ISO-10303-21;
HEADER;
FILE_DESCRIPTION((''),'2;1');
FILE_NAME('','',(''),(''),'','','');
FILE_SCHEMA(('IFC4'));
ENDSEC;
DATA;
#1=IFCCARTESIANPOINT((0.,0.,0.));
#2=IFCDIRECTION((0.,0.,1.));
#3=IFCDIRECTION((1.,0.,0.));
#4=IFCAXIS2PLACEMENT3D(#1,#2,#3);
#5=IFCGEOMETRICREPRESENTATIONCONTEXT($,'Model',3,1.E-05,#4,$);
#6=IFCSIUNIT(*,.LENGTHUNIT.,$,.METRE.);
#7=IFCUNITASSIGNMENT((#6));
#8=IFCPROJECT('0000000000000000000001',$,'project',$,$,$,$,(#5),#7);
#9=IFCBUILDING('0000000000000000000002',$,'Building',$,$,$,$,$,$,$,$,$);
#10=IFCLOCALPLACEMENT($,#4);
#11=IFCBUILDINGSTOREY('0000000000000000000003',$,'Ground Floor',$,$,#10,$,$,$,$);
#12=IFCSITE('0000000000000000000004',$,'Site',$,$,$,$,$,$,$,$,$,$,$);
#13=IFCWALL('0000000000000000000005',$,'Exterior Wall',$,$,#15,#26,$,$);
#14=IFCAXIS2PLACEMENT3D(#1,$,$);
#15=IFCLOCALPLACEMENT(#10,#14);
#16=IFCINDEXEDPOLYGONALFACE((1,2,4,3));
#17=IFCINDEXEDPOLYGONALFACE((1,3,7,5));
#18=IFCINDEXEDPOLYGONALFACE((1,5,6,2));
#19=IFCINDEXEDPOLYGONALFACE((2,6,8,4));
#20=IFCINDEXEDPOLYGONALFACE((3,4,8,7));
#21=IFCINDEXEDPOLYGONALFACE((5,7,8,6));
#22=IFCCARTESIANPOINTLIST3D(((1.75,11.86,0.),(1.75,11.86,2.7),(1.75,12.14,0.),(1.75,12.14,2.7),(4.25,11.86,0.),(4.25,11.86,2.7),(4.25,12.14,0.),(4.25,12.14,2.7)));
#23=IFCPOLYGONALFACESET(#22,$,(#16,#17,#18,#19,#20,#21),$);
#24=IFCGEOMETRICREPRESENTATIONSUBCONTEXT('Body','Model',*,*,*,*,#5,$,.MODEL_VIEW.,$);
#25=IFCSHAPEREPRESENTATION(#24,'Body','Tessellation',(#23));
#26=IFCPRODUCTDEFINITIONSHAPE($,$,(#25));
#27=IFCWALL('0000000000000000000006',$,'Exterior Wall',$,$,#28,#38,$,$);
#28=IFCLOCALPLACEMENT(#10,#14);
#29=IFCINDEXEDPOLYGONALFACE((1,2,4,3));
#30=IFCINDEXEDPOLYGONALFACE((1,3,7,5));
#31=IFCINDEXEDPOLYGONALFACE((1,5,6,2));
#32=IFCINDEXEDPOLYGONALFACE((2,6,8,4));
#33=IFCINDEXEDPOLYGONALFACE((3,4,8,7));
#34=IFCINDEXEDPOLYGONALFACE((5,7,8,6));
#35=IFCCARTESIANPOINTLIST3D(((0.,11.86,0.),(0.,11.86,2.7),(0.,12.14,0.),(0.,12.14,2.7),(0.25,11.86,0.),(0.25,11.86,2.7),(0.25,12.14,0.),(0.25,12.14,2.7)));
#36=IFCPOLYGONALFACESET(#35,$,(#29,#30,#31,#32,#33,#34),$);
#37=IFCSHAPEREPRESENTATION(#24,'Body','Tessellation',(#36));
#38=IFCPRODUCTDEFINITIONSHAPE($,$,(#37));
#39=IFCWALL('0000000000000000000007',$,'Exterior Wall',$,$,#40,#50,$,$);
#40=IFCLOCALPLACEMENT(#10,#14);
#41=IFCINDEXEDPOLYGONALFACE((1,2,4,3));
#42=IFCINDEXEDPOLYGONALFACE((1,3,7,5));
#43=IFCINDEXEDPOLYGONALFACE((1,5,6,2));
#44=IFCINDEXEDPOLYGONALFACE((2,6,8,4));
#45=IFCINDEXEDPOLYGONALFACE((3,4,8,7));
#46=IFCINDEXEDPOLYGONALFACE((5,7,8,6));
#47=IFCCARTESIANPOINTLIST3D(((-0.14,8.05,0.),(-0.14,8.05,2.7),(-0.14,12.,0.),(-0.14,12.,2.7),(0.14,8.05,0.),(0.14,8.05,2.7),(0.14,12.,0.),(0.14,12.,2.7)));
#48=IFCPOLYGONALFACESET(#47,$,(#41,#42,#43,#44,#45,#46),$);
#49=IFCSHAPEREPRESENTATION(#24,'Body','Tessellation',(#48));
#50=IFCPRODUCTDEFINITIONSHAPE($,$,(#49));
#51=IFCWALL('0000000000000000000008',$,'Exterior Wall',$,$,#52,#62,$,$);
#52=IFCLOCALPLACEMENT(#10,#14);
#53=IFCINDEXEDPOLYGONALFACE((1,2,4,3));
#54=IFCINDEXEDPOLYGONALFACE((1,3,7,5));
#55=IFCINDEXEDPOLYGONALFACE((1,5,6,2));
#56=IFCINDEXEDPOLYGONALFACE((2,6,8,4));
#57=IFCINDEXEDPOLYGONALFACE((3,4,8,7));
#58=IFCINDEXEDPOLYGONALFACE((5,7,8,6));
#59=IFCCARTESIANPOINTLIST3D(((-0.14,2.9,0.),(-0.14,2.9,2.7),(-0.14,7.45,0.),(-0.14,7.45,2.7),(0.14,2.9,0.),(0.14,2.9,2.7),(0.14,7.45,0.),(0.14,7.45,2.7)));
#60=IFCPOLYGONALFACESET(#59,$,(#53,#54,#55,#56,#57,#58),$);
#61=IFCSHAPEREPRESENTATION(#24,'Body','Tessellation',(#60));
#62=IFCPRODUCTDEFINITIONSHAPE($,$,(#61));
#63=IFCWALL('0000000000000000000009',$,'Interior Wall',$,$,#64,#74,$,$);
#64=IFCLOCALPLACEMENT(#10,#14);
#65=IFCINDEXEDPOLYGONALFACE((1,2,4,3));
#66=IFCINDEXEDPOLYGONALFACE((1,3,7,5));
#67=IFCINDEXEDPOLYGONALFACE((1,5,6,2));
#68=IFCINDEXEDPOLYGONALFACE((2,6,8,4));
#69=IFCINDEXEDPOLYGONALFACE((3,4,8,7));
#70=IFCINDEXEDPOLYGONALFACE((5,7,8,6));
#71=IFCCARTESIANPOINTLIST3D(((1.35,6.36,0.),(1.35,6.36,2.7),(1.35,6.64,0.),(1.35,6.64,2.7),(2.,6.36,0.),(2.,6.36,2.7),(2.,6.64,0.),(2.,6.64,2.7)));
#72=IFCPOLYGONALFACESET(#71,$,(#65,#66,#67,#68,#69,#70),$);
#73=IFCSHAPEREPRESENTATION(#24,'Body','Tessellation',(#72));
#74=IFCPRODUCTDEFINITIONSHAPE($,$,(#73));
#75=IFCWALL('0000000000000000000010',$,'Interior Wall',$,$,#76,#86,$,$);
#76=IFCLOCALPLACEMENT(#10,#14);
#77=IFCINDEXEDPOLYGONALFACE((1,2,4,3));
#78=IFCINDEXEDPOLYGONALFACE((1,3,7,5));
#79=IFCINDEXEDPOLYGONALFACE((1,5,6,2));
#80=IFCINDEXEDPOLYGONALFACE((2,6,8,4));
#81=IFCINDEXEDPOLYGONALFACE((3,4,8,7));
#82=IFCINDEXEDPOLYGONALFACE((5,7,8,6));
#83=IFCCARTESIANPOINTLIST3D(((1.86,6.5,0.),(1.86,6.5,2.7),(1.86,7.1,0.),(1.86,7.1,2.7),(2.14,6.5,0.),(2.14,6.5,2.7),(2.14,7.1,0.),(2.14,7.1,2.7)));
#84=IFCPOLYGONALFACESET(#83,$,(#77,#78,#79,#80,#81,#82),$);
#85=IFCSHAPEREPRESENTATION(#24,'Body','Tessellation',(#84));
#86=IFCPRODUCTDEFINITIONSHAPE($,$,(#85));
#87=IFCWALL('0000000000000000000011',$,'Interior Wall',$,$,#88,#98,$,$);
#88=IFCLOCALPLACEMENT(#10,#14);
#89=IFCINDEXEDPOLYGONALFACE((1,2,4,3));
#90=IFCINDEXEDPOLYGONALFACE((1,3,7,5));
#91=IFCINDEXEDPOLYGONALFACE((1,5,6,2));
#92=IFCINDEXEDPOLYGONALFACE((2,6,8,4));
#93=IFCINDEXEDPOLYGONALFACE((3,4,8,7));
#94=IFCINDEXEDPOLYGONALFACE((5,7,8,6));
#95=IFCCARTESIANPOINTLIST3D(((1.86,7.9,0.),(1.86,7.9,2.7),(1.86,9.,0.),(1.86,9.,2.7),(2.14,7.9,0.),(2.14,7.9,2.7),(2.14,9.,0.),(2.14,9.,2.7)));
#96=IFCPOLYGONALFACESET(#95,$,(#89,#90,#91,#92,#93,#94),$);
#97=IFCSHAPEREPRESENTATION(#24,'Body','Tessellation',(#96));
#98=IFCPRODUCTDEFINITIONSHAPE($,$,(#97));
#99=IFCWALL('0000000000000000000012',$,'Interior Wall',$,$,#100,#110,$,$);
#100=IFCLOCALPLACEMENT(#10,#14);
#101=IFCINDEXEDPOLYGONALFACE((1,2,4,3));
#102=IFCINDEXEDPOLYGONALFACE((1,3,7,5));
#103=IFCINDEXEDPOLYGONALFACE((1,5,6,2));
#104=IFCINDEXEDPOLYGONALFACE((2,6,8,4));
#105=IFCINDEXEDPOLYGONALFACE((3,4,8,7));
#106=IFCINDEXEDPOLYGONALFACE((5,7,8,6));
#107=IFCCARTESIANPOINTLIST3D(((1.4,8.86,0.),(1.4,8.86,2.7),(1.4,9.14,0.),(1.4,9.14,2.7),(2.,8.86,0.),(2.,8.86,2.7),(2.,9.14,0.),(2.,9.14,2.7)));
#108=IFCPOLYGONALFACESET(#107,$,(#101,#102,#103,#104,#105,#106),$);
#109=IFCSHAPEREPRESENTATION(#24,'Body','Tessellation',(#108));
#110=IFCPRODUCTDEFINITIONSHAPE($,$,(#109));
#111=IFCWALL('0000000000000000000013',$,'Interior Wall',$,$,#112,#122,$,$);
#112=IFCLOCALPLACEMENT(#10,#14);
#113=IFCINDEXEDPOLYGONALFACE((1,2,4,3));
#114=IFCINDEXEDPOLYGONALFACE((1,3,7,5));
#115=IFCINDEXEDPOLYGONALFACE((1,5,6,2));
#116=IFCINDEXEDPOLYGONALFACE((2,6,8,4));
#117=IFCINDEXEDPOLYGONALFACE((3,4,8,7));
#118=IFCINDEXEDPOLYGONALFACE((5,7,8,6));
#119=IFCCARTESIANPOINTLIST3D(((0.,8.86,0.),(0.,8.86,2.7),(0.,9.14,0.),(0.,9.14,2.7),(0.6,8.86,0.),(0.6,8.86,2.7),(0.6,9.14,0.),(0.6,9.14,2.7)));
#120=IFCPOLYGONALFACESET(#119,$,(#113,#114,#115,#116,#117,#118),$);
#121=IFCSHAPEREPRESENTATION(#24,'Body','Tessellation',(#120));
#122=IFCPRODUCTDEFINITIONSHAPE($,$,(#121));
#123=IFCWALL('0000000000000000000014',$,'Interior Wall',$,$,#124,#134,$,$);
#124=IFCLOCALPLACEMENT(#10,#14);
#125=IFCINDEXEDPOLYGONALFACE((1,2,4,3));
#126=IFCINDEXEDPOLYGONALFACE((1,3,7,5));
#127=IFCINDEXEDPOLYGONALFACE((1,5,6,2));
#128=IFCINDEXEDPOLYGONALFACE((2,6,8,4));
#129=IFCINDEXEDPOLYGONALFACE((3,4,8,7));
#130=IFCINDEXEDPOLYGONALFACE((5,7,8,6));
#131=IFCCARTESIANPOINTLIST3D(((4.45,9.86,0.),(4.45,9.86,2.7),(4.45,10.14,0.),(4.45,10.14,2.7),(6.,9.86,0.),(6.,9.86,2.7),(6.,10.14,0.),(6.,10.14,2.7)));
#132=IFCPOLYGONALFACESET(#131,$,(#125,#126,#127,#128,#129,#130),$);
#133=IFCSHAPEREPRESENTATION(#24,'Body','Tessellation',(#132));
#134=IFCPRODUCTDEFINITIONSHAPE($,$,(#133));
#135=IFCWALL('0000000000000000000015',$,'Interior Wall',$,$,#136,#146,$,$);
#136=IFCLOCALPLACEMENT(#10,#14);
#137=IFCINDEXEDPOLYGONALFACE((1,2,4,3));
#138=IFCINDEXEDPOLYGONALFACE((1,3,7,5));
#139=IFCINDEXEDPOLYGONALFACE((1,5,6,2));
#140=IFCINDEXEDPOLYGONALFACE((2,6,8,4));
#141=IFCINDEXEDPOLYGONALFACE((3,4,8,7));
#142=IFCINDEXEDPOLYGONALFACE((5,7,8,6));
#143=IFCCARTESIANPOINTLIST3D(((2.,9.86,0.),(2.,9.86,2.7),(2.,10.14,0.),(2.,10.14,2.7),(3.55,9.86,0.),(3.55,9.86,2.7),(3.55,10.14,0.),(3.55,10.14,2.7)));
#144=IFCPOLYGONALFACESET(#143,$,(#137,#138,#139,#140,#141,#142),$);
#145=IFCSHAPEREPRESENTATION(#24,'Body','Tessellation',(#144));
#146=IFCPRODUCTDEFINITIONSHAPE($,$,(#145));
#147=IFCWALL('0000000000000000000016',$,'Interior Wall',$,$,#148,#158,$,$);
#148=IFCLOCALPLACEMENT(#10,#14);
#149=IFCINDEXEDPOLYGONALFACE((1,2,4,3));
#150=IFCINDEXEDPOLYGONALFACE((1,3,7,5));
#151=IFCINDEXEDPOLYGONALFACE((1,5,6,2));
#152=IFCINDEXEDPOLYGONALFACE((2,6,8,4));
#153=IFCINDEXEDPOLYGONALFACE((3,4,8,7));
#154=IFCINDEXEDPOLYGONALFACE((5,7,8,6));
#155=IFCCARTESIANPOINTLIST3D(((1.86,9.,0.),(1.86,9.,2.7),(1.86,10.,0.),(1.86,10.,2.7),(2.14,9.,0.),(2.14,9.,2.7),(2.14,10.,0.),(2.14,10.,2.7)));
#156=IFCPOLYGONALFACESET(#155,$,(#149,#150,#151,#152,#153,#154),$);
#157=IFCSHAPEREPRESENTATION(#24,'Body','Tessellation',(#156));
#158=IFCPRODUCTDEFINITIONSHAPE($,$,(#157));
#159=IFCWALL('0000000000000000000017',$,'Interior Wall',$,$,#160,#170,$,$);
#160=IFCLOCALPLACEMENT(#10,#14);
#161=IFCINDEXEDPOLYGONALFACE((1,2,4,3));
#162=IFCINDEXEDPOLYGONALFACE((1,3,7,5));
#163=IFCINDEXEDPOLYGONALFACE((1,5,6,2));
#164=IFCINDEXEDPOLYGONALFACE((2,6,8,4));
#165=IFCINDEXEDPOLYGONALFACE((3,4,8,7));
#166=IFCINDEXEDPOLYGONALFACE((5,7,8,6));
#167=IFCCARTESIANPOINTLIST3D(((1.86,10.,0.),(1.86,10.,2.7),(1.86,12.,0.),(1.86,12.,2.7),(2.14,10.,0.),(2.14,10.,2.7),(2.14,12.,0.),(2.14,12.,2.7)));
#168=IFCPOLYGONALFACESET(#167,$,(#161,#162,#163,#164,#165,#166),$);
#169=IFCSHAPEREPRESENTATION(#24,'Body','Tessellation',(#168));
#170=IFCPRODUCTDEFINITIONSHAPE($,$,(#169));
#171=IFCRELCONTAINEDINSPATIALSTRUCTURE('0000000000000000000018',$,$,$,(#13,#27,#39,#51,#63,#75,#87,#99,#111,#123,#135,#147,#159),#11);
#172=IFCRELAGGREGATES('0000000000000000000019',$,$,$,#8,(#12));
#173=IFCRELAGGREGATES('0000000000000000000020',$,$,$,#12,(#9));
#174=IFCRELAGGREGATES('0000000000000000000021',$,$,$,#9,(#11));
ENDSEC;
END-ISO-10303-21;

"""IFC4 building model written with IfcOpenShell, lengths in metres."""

from ifc_helpers import new_model, si_unit, frame, origin_with_axes, place, context, subcontext, project, spatial, indexed_curve, outline, extrude, element, save


model = new_model("IFC4")

# Units and contexts
model_context = context("Model", 3, precision=1e-05, world=origin_with_axes())
body_context = subcontext(model_context, "Body", "Model", "MODEL_VIEW")
ifc_project = project(units=[si_unit("LENGTHUNIT", "METRE")], contexts=[model_context])

# Site, building, storey
site = spatial("IfcSite", under=ifc_project, Name="Site")
building = spatial("IfcBuilding", under=site, Name="Building")
storey_placement = place(None, origin_with_axes())
storey = spatial("IfcBuildingStorey", under=building, at=storey_placement, Name="Ground Floor")

# Walls
wall_1_placement = place(storey_placement, frame((4.25, 12.0, 0.0), z_axis=(0.0, 0.0, 1.0), x_axis=(-1.0, 0.0, 0.0)))
element("IfcWall", 1, at=wall_1_placement, inside=storey, Name="Exterior Wall", context=body_context, shape_type="SweptSolid", body=[
    extrude(outline(indexed_curve([(0.0, 0.0), (0.0, 0.28), (2.5, 0.28), (2.5, 0.0), (0.0, 0.0)], self_intersect=False)), frame((0.0, -0.14, 0.0), z_axis=(0.0, 0.0, 1.0), x_axis=(1.0, 0.0, 0.0)), (0.0, 0.0, 1.0), 2.7),
])
wall_2_placement = place(storey_placement, frame((0.25, 12.0, 0.0), z_axis=(0.0, 0.0, 1.0), x_axis=(-1.0, 0.0, 0.0)))
element("IfcWall", 2, at=wall_2_placement, inside=storey, Name="Exterior Wall", context=body_context, shape_type="SweptSolid", body=[
    extrude(outline(indexed_curve([(0.0, 0.0), (0.0, 0.28), (0.25, 0.28), (0.25, 0.0), (0.0, 0.0)], self_intersect=False)), frame((0.0, -0.14, 0.0), z_axis=(0.0, 0.0, 1.0), x_axis=(1.0, 0.0, 0.0)), (0.0, 0.0, 1.0), 2.7),
])
wall_3_placement = place(storey_placement, frame((0.0, 12.0, 0.0), z_axis=(0.0, 0.0, 1.0), x_axis=(0.0, -1.0, 0.0)))
element("IfcWall", 3, at=wall_3_placement, inside=storey, Name="Exterior Wall", context=body_context, shape_type="SweptSolid", body=[
    extrude(outline(indexed_curve([(0.0, 0.0), (0.0, 0.28), (3.95, 0.28), (3.95, 0.0), (0.0, 0.0)], self_intersect=False)), frame((0.0, -0.14, 0.0), z_axis=(0.0, 0.0, 1.0), x_axis=(1.0, 0.0, 0.0)), (0.0, 0.0, 1.0), 2.7),
])
wall_4_placement = place(storey_placement, frame((0.0, 7.45, 0.0), z_axis=(0.0, 0.0, 1.0), x_axis=(0.0, -1.0, 0.0)))
element("IfcWall", 4, at=wall_4_placement, inside=storey, Name="Exterior Wall", context=body_context, shape_type="SweptSolid", body=[
    extrude(outline(indexed_curve([(0.0, 0.0), (0.0, 0.28), (4.55, 0.28), (4.55, 0.0), (0.0, 0.0)], self_intersect=False)), frame((0.0, -0.14, 0.0), z_axis=(0.0, 0.0, 1.0), x_axis=(1.0, 0.0, 0.0)), (0.0, 0.0, 1.0), 2.7),
])
wall_5_placement = place(storey_placement, frame((2.0, 6.5, 0.0), z_axis=(0.0, 0.0, 1.0), x_axis=(-1.0, 0.0, 0.0)))
element("IfcWall", 5, at=wall_5_placement, inside=storey, Name="Interior Wall", context=body_context, shape_type="SweptSolid", body=[
    extrude(outline(indexed_curve([(0.0, 0.0), (0.0, 0.28), (0.65, 0.28), (0.65, 0.0), (0.0, 0.0)], self_intersect=False)), frame((0.0, -0.14, 0.0), z_axis=(0.0, 0.0, 1.0), x_axis=(1.0, 0.0, 0.0)), (0.0, 0.0, 1.0), 2.7),
])
wall_6_placement = place(storey_placement, frame((2.0, 6.5, 0.0), z_axis=(0.0, 0.0, 1.0), x_axis=(0.0, 1.0, 0.0)))
element("IfcWall", 6, at=wall_6_placement, inside=storey, Name="Interior Wall", context=body_context, shape_type="SweptSolid", body=[
    extrude(outline(indexed_curve([(0.0, 0.0), (0.0, 0.28), (0.6, 0.28), (0.6, 0.0), (0.0, 0.0)], self_intersect=False)), frame((0.0, -0.14, 0.0), z_axis=(0.0, 0.0, 1.0), x_axis=(1.0, 0.0, 0.0)), (0.0, 0.0, 1.0), 2.7),
])
wall_7_placement = place(storey_placement, frame((2.0, 7.9, 0.0), z_axis=(0.0, 0.0, 1.0), x_axis=(0.0, 1.0, 0.0)))
element("IfcWall", 7, at=wall_7_placement, inside=storey, Name="Interior Wall", context=body_context, shape_type="SweptSolid", body=[
    extrude(outline(indexed_curve([(0.0, 0.0), (0.0, 0.28), (1.1, 0.28), (1.1, 0.0), (0.0, 0.0)], self_intersect=False)), frame((0.0, -0.14, 0.0), z_axis=(0.0, 0.0, 1.0), x_axis=(1.0, 0.0, 0.0)), (0.0, 0.0, 1.0), 2.7),
])
for number, where, z_axis, x_axis, name in (
    (8, (2.0, 9.0, 0.0), (0.0, 0.0, 1.0), (-1.0, 0.0, 0.0), "Interior Wall"),
    (9, (0.6, 9.0, 0.0), (0.0, 0.0, 1.0), (-1.0, 0.0, 0.0), "Interior Wall"),
):
    element("IfcWall", number, at=place(storey_placement, frame(where, z_axis=z_axis, x_axis=x_axis)), inside=storey, Name=name, context=body_context, shape_type="SweptSolid", body=[
        extrude(outline(indexed_curve([(0.0, 0.0), (0.0, 0.28), (0.6, 0.28), (0.6, 0.0), (0.0, 0.0)], self_intersect=False)), frame((0.0, -0.14, 0.0), z_axis=(0.0, 0.0, 1.0), x_axis=(1.0, 0.0, 0.0)), (0.0, 0.0, 1.0), 2.7),
    ])
for number, where, z_axis, x_axis, name in (
    (10, (6.0, 10.0, 0.0), (0.0, 0.0, 1.0), (-1.0, 0.0, 0.0), "Interior Wall"),
    (11, (3.55, 10.0, 0.0), (0.0, 0.0, 1.0), (-1.0, 0.0, 0.0), "Interior Wall"),
):
    element("IfcWall", number, at=place(storey_placement, frame(where, z_axis=z_axis, x_axis=x_axis)), inside=storey, Name=name, context=body_context, shape_type="SweptSolid", body=[
        extrude(outline(indexed_curve([(0.0, 0.0), (0.0, 0.28), (1.55, 0.28), (1.55, 0.0), (0.0, 0.0)], self_intersect=False)), frame((0.0, -0.14, 0.0), z_axis=(0.0, 0.0, 1.0), x_axis=(1.0, 0.0, 0.0)), (0.0, 0.0, 1.0), 2.7),
    ])
wall_8_placement = place(storey_placement, frame((2.0, 10.0, 0.0), z_axis=(0.0, 0.0, 1.0), x_axis=(0.0, -1.0, 0.0)))
element("IfcWall", 12, at=wall_8_placement, inside=storey, Name="Interior Wall", context=body_context, shape_type="SweptSolid", body=[
    extrude(outline(indexed_curve([(0.0, 0.0), (0.0, 0.28), (1.0, 0.28), (1.0, 0.0), (0.0, 0.0)], self_intersect=False)), frame((0.0, -0.14, 0.0), z_axis=(0.0, 0.0, 1.0), x_axis=(1.0, 0.0, 0.0)), (0.0, 0.0, 1.0), 2.7),
])
wall_9_placement = place(storey_placement, frame((2.0, 12.0, 0.0), z_axis=(0.0, 0.0, 1.0), x_axis=(0.0, -1.0, 0.0)))
element("IfcWall", 13, at=wall_9_placement, inside=storey, Name="Interior Wall", context=body_context, shape_type="SweptSolid", body=[
    extrude(outline(indexed_curve([(0.0, 0.0), (0.0, 0.28), (2.0, 0.28), (2.0, 0.0), (0.0, 0.0)], self_intersect=False)), frame((0.0, -0.14, 0.0), z_axis=(0.0, 0.0, 1.0), x_axis=(1.0, 0.0, 0.0)), (0.0, 0.0, 1.0), 2.7),
])

save(model, "model.ifc")
